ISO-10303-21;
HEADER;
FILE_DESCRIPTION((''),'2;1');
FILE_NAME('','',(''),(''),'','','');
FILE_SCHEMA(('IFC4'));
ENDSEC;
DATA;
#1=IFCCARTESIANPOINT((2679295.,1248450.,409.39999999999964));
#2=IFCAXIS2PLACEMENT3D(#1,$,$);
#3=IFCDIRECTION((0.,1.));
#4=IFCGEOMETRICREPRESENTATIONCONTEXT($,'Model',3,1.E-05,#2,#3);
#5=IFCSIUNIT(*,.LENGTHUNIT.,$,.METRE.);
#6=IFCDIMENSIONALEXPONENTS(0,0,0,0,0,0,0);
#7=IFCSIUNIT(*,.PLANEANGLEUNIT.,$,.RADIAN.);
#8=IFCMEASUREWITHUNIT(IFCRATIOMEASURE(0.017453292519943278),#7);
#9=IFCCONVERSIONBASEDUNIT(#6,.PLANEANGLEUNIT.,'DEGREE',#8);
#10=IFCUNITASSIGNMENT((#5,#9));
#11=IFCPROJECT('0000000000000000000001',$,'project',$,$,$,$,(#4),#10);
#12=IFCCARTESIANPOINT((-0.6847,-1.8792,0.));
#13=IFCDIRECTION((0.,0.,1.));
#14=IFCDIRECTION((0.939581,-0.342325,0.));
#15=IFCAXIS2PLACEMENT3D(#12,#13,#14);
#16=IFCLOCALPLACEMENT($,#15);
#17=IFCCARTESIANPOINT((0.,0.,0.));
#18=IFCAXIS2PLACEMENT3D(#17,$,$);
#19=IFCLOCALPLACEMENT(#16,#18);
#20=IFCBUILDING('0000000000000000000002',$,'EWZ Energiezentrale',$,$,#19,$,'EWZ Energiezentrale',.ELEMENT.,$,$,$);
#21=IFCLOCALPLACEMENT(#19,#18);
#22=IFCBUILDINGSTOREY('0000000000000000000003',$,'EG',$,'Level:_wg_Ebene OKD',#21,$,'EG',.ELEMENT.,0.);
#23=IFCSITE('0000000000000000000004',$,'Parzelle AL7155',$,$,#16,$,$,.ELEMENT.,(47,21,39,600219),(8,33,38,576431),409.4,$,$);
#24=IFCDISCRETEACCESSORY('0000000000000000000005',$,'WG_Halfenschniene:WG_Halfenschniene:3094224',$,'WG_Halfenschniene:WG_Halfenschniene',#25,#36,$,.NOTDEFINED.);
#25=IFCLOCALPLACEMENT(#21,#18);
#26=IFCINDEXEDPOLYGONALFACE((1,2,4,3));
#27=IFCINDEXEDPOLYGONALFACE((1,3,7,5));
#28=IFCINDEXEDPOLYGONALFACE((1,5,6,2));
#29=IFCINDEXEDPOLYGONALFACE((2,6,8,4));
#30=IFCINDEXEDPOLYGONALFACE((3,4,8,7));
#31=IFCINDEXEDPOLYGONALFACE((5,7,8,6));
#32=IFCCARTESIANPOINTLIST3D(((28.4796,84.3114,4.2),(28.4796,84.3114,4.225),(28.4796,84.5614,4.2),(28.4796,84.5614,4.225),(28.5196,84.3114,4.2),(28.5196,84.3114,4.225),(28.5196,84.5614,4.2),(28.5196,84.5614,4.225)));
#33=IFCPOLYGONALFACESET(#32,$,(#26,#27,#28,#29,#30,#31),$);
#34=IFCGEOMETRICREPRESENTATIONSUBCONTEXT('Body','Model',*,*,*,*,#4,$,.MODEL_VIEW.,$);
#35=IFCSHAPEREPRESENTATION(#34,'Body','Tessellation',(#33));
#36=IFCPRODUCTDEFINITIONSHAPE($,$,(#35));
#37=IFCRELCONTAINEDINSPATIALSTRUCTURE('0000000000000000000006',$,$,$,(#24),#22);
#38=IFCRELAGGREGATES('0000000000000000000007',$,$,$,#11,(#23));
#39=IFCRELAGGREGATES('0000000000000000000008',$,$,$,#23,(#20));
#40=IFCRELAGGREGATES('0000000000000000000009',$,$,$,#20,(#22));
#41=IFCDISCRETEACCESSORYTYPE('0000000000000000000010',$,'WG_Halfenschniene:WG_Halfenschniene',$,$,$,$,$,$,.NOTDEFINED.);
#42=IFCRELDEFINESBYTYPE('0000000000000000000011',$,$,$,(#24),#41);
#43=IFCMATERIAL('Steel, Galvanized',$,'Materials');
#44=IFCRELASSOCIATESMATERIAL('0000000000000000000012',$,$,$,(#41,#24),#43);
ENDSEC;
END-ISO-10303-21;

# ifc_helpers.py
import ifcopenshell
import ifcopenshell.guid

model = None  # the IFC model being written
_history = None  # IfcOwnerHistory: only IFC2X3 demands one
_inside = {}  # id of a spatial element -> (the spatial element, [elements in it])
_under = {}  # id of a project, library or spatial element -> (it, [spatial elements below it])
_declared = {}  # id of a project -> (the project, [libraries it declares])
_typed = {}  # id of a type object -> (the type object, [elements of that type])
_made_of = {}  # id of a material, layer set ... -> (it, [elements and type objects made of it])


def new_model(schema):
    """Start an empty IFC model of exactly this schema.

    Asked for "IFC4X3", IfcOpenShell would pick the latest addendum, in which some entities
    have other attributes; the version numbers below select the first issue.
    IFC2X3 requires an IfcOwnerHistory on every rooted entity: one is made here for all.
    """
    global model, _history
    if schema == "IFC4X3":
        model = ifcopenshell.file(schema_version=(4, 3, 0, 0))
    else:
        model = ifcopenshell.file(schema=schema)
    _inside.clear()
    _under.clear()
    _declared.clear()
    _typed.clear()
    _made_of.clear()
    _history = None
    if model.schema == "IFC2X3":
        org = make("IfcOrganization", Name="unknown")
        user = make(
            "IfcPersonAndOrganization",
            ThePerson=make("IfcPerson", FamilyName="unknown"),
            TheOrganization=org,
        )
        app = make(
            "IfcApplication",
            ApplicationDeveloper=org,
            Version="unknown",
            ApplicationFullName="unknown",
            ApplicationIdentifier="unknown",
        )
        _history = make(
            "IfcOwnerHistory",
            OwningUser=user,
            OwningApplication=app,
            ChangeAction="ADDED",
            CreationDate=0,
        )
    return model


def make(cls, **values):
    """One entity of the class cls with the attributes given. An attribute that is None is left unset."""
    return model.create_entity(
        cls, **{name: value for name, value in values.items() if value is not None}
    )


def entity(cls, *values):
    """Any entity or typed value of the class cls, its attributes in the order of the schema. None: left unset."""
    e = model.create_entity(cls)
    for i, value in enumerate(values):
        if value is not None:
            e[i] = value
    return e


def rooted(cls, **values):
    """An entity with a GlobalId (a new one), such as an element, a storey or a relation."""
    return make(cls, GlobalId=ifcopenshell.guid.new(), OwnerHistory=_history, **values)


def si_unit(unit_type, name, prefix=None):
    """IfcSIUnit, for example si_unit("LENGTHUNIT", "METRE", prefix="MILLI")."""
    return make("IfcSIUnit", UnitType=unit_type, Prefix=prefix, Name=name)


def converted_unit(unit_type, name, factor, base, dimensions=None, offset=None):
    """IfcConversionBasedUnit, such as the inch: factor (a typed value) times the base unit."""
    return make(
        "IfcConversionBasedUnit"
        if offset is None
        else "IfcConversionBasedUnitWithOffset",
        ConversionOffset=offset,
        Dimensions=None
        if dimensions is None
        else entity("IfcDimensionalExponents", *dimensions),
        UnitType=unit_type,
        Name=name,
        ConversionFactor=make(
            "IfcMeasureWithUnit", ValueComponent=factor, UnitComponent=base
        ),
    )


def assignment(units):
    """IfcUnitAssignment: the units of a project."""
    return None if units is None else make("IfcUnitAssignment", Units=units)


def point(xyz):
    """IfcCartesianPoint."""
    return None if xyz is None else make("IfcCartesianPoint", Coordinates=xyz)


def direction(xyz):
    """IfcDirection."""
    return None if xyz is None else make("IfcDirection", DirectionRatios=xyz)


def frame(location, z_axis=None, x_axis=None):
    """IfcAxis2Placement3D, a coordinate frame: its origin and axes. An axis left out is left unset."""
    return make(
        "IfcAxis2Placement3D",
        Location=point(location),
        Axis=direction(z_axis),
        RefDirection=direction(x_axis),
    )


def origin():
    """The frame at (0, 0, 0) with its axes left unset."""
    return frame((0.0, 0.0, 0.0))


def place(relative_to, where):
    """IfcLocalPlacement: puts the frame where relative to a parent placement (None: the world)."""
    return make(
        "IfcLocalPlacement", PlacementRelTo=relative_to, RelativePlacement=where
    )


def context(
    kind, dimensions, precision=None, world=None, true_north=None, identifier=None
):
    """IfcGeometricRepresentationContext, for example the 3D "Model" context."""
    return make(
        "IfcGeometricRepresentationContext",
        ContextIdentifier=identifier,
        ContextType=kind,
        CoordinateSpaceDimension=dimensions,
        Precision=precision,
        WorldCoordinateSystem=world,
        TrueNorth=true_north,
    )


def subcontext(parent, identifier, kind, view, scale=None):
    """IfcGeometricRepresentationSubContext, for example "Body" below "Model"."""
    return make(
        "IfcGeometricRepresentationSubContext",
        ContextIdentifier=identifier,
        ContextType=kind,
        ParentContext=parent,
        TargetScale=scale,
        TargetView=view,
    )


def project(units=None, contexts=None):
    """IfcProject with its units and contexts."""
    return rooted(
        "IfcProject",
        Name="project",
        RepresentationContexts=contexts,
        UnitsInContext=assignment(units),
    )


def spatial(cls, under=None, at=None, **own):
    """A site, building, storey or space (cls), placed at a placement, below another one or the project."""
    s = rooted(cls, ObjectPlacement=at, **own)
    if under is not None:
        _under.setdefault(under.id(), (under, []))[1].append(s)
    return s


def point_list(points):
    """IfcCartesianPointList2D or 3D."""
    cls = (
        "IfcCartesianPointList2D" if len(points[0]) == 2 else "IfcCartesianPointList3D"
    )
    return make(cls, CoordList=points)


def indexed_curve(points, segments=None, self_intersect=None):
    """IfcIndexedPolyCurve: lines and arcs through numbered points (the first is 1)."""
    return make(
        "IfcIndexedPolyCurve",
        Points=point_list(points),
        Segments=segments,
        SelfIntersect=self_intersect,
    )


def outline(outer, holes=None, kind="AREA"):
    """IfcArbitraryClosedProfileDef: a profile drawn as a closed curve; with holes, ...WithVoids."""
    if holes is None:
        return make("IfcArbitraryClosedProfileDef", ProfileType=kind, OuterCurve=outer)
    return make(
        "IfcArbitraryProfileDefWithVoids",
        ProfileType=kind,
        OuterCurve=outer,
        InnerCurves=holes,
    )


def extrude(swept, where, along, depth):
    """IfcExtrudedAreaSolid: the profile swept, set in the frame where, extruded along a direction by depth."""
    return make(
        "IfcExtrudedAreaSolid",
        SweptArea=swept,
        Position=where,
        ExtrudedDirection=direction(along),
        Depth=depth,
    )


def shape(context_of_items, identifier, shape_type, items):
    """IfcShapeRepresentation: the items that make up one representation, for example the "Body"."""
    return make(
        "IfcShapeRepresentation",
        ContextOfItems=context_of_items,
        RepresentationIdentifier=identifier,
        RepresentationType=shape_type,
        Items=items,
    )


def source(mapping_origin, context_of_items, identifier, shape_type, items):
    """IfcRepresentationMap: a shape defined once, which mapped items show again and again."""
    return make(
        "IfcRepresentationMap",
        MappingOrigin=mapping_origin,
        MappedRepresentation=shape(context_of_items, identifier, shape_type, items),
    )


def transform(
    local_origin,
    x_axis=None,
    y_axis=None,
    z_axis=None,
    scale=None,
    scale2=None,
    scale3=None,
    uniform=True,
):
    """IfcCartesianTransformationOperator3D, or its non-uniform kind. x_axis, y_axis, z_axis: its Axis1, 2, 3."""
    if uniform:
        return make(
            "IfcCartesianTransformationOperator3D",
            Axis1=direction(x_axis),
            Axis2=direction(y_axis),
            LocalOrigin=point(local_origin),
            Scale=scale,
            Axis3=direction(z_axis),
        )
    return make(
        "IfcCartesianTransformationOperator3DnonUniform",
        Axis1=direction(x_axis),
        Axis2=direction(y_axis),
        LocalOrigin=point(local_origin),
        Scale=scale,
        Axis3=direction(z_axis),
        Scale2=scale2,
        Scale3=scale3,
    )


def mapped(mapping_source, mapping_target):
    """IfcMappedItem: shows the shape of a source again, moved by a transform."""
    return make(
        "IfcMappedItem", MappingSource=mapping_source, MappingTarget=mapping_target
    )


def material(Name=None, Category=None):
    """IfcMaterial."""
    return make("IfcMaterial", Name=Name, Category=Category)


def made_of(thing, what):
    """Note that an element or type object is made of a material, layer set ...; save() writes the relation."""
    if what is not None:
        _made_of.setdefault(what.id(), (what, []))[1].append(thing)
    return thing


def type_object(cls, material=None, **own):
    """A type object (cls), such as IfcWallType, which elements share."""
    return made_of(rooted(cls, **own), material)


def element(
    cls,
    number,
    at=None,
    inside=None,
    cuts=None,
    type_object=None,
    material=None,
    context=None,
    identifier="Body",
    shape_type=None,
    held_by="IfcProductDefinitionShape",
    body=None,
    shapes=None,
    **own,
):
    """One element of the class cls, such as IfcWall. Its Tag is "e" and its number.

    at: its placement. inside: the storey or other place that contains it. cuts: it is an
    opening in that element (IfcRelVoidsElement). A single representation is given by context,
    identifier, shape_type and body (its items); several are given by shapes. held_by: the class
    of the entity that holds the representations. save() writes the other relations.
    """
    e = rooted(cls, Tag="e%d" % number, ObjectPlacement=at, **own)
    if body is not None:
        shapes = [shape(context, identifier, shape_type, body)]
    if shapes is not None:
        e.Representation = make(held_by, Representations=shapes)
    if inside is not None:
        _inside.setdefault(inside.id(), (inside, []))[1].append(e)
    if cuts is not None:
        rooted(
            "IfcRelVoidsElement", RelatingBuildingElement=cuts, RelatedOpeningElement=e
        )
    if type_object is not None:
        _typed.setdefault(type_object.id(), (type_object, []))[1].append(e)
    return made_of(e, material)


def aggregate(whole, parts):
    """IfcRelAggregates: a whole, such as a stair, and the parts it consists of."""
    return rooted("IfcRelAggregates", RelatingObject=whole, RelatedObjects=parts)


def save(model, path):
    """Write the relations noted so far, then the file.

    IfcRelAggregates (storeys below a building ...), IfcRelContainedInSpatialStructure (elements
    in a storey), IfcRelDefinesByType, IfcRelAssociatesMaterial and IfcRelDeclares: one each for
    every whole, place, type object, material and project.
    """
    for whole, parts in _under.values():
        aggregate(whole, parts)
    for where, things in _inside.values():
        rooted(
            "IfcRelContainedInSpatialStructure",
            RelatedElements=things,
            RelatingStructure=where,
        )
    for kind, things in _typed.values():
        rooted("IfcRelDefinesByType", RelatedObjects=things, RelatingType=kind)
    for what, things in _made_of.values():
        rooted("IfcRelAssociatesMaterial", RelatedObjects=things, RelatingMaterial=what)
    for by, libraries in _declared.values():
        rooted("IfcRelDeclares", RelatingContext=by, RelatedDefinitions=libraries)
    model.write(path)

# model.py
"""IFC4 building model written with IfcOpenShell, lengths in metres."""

from ifc_helpers import new_model, entity, si_unit, converted_unit, direction, frame, origin, place, context, subcontext, project, spatial, indexed_curve, outline, extrude, source, transform, mapped, material, type_object, element, save


model = new_model("IFC4")

# Units and contexts
model_context = context("Model", 3, precision=1e-05, world=frame((2679295.0, 1248450.0, 409.39999999999964)), true_north=direction((0.0, 1.0)))
body_context = subcontext(model_context, "Body", "Model", "MODEL_VIEW")
ifc_project = project(units=[si_unit("LENGTHUNIT", "METRE"), converted_unit("PLANEANGLEUNIT", "DEGREE", entity("IfcRatioMeasure", 0.017453292519943278), si_unit("PLANEANGLEUNIT", "RADIAN"), dimensions=[0, 0, 0, 0, 0, 0, 0])], contexts=[model_context])

# Site, building, storey
site_placement = place(None, frame((-0.6847, -1.8792, 0.0), z_axis=(0.0, 0.0, 1.0), x_axis=(0.939581, -0.342325, 0.0)))
site = spatial("IfcSite", under=ifc_project, at=site_placement, Name="Parzelle AL7155", CompositionType="ELEMENT", RefLatitude=(47, 21, 39, 600219), RefLongitude=(8, 33, 38, 576431), RefElevation=409.4)
building_placement = place(site_placement, origin())
building = spatial("IfcBuilding", under=site, at=building_placement, Name="EWZ Energiezentrale", LongName="EWZ Energiezentrale", CompositionType="ELEMENT")
storey_placement = place(building_placement, origin())
storey = spatial("IfcBuildingStorey", under=building, at=storey_placement, Name="EG", ObjectType="Level:_wg_Ebene OKD", LongName="EG", CompositionType="ELEMENT", Elevation=0.0)

# Discrete accessory
ifc_material = material(Name="Steel, Galvanized", Category="Materials")
discrete_accessory_type = type_object("IfcDiscreteAccessoryType", Name="WG_Halfenschniene:WG_Halfenschniene", PredefinedType="NOTDEFINED", material=ifc_material)
shared_shape = source(origin(), body_context, "Body", "SweptSolid", [
    extrude(outline(indexed_curve([(-0.125, -0.02), (0.125, -0.02), (0.125, 0.02), (-0.125, 0.02), (-0.125, -0.02)], self_intersect=False)), frame((0.125, 0.0, -0.0125)), (0.0, 0.0, 1.0), 0.025),
])
for number, where, z_axis, x_axis, name in (
    (1, (28.4996, 84.3114, 4.2125), (0.0, 0.0, -1.0), (0.0, 1.0, 0.0), "WG_Halfenschniene:WG_Halfenschniene:3094224"),
):
    element("IfcDiscreteAccessory", number, at=place(storey_placement, frame(where, z_axis=z_axis, x_axis=x_axis)), inside=storey, type_object=discrete_accessory_type, material=ifc_material, Name=name, ObjectType="WG_Halfenschniene:WG_Halfenschniene", PredefinedType="NOTDEFINED", context=body_context, shape_type="MappedRepresentation", body=[
        mapped(shared_shape, transform((0.0, 0.0, 0.0), scale=1.0)),
    ])

save(model, "model.ifc")
